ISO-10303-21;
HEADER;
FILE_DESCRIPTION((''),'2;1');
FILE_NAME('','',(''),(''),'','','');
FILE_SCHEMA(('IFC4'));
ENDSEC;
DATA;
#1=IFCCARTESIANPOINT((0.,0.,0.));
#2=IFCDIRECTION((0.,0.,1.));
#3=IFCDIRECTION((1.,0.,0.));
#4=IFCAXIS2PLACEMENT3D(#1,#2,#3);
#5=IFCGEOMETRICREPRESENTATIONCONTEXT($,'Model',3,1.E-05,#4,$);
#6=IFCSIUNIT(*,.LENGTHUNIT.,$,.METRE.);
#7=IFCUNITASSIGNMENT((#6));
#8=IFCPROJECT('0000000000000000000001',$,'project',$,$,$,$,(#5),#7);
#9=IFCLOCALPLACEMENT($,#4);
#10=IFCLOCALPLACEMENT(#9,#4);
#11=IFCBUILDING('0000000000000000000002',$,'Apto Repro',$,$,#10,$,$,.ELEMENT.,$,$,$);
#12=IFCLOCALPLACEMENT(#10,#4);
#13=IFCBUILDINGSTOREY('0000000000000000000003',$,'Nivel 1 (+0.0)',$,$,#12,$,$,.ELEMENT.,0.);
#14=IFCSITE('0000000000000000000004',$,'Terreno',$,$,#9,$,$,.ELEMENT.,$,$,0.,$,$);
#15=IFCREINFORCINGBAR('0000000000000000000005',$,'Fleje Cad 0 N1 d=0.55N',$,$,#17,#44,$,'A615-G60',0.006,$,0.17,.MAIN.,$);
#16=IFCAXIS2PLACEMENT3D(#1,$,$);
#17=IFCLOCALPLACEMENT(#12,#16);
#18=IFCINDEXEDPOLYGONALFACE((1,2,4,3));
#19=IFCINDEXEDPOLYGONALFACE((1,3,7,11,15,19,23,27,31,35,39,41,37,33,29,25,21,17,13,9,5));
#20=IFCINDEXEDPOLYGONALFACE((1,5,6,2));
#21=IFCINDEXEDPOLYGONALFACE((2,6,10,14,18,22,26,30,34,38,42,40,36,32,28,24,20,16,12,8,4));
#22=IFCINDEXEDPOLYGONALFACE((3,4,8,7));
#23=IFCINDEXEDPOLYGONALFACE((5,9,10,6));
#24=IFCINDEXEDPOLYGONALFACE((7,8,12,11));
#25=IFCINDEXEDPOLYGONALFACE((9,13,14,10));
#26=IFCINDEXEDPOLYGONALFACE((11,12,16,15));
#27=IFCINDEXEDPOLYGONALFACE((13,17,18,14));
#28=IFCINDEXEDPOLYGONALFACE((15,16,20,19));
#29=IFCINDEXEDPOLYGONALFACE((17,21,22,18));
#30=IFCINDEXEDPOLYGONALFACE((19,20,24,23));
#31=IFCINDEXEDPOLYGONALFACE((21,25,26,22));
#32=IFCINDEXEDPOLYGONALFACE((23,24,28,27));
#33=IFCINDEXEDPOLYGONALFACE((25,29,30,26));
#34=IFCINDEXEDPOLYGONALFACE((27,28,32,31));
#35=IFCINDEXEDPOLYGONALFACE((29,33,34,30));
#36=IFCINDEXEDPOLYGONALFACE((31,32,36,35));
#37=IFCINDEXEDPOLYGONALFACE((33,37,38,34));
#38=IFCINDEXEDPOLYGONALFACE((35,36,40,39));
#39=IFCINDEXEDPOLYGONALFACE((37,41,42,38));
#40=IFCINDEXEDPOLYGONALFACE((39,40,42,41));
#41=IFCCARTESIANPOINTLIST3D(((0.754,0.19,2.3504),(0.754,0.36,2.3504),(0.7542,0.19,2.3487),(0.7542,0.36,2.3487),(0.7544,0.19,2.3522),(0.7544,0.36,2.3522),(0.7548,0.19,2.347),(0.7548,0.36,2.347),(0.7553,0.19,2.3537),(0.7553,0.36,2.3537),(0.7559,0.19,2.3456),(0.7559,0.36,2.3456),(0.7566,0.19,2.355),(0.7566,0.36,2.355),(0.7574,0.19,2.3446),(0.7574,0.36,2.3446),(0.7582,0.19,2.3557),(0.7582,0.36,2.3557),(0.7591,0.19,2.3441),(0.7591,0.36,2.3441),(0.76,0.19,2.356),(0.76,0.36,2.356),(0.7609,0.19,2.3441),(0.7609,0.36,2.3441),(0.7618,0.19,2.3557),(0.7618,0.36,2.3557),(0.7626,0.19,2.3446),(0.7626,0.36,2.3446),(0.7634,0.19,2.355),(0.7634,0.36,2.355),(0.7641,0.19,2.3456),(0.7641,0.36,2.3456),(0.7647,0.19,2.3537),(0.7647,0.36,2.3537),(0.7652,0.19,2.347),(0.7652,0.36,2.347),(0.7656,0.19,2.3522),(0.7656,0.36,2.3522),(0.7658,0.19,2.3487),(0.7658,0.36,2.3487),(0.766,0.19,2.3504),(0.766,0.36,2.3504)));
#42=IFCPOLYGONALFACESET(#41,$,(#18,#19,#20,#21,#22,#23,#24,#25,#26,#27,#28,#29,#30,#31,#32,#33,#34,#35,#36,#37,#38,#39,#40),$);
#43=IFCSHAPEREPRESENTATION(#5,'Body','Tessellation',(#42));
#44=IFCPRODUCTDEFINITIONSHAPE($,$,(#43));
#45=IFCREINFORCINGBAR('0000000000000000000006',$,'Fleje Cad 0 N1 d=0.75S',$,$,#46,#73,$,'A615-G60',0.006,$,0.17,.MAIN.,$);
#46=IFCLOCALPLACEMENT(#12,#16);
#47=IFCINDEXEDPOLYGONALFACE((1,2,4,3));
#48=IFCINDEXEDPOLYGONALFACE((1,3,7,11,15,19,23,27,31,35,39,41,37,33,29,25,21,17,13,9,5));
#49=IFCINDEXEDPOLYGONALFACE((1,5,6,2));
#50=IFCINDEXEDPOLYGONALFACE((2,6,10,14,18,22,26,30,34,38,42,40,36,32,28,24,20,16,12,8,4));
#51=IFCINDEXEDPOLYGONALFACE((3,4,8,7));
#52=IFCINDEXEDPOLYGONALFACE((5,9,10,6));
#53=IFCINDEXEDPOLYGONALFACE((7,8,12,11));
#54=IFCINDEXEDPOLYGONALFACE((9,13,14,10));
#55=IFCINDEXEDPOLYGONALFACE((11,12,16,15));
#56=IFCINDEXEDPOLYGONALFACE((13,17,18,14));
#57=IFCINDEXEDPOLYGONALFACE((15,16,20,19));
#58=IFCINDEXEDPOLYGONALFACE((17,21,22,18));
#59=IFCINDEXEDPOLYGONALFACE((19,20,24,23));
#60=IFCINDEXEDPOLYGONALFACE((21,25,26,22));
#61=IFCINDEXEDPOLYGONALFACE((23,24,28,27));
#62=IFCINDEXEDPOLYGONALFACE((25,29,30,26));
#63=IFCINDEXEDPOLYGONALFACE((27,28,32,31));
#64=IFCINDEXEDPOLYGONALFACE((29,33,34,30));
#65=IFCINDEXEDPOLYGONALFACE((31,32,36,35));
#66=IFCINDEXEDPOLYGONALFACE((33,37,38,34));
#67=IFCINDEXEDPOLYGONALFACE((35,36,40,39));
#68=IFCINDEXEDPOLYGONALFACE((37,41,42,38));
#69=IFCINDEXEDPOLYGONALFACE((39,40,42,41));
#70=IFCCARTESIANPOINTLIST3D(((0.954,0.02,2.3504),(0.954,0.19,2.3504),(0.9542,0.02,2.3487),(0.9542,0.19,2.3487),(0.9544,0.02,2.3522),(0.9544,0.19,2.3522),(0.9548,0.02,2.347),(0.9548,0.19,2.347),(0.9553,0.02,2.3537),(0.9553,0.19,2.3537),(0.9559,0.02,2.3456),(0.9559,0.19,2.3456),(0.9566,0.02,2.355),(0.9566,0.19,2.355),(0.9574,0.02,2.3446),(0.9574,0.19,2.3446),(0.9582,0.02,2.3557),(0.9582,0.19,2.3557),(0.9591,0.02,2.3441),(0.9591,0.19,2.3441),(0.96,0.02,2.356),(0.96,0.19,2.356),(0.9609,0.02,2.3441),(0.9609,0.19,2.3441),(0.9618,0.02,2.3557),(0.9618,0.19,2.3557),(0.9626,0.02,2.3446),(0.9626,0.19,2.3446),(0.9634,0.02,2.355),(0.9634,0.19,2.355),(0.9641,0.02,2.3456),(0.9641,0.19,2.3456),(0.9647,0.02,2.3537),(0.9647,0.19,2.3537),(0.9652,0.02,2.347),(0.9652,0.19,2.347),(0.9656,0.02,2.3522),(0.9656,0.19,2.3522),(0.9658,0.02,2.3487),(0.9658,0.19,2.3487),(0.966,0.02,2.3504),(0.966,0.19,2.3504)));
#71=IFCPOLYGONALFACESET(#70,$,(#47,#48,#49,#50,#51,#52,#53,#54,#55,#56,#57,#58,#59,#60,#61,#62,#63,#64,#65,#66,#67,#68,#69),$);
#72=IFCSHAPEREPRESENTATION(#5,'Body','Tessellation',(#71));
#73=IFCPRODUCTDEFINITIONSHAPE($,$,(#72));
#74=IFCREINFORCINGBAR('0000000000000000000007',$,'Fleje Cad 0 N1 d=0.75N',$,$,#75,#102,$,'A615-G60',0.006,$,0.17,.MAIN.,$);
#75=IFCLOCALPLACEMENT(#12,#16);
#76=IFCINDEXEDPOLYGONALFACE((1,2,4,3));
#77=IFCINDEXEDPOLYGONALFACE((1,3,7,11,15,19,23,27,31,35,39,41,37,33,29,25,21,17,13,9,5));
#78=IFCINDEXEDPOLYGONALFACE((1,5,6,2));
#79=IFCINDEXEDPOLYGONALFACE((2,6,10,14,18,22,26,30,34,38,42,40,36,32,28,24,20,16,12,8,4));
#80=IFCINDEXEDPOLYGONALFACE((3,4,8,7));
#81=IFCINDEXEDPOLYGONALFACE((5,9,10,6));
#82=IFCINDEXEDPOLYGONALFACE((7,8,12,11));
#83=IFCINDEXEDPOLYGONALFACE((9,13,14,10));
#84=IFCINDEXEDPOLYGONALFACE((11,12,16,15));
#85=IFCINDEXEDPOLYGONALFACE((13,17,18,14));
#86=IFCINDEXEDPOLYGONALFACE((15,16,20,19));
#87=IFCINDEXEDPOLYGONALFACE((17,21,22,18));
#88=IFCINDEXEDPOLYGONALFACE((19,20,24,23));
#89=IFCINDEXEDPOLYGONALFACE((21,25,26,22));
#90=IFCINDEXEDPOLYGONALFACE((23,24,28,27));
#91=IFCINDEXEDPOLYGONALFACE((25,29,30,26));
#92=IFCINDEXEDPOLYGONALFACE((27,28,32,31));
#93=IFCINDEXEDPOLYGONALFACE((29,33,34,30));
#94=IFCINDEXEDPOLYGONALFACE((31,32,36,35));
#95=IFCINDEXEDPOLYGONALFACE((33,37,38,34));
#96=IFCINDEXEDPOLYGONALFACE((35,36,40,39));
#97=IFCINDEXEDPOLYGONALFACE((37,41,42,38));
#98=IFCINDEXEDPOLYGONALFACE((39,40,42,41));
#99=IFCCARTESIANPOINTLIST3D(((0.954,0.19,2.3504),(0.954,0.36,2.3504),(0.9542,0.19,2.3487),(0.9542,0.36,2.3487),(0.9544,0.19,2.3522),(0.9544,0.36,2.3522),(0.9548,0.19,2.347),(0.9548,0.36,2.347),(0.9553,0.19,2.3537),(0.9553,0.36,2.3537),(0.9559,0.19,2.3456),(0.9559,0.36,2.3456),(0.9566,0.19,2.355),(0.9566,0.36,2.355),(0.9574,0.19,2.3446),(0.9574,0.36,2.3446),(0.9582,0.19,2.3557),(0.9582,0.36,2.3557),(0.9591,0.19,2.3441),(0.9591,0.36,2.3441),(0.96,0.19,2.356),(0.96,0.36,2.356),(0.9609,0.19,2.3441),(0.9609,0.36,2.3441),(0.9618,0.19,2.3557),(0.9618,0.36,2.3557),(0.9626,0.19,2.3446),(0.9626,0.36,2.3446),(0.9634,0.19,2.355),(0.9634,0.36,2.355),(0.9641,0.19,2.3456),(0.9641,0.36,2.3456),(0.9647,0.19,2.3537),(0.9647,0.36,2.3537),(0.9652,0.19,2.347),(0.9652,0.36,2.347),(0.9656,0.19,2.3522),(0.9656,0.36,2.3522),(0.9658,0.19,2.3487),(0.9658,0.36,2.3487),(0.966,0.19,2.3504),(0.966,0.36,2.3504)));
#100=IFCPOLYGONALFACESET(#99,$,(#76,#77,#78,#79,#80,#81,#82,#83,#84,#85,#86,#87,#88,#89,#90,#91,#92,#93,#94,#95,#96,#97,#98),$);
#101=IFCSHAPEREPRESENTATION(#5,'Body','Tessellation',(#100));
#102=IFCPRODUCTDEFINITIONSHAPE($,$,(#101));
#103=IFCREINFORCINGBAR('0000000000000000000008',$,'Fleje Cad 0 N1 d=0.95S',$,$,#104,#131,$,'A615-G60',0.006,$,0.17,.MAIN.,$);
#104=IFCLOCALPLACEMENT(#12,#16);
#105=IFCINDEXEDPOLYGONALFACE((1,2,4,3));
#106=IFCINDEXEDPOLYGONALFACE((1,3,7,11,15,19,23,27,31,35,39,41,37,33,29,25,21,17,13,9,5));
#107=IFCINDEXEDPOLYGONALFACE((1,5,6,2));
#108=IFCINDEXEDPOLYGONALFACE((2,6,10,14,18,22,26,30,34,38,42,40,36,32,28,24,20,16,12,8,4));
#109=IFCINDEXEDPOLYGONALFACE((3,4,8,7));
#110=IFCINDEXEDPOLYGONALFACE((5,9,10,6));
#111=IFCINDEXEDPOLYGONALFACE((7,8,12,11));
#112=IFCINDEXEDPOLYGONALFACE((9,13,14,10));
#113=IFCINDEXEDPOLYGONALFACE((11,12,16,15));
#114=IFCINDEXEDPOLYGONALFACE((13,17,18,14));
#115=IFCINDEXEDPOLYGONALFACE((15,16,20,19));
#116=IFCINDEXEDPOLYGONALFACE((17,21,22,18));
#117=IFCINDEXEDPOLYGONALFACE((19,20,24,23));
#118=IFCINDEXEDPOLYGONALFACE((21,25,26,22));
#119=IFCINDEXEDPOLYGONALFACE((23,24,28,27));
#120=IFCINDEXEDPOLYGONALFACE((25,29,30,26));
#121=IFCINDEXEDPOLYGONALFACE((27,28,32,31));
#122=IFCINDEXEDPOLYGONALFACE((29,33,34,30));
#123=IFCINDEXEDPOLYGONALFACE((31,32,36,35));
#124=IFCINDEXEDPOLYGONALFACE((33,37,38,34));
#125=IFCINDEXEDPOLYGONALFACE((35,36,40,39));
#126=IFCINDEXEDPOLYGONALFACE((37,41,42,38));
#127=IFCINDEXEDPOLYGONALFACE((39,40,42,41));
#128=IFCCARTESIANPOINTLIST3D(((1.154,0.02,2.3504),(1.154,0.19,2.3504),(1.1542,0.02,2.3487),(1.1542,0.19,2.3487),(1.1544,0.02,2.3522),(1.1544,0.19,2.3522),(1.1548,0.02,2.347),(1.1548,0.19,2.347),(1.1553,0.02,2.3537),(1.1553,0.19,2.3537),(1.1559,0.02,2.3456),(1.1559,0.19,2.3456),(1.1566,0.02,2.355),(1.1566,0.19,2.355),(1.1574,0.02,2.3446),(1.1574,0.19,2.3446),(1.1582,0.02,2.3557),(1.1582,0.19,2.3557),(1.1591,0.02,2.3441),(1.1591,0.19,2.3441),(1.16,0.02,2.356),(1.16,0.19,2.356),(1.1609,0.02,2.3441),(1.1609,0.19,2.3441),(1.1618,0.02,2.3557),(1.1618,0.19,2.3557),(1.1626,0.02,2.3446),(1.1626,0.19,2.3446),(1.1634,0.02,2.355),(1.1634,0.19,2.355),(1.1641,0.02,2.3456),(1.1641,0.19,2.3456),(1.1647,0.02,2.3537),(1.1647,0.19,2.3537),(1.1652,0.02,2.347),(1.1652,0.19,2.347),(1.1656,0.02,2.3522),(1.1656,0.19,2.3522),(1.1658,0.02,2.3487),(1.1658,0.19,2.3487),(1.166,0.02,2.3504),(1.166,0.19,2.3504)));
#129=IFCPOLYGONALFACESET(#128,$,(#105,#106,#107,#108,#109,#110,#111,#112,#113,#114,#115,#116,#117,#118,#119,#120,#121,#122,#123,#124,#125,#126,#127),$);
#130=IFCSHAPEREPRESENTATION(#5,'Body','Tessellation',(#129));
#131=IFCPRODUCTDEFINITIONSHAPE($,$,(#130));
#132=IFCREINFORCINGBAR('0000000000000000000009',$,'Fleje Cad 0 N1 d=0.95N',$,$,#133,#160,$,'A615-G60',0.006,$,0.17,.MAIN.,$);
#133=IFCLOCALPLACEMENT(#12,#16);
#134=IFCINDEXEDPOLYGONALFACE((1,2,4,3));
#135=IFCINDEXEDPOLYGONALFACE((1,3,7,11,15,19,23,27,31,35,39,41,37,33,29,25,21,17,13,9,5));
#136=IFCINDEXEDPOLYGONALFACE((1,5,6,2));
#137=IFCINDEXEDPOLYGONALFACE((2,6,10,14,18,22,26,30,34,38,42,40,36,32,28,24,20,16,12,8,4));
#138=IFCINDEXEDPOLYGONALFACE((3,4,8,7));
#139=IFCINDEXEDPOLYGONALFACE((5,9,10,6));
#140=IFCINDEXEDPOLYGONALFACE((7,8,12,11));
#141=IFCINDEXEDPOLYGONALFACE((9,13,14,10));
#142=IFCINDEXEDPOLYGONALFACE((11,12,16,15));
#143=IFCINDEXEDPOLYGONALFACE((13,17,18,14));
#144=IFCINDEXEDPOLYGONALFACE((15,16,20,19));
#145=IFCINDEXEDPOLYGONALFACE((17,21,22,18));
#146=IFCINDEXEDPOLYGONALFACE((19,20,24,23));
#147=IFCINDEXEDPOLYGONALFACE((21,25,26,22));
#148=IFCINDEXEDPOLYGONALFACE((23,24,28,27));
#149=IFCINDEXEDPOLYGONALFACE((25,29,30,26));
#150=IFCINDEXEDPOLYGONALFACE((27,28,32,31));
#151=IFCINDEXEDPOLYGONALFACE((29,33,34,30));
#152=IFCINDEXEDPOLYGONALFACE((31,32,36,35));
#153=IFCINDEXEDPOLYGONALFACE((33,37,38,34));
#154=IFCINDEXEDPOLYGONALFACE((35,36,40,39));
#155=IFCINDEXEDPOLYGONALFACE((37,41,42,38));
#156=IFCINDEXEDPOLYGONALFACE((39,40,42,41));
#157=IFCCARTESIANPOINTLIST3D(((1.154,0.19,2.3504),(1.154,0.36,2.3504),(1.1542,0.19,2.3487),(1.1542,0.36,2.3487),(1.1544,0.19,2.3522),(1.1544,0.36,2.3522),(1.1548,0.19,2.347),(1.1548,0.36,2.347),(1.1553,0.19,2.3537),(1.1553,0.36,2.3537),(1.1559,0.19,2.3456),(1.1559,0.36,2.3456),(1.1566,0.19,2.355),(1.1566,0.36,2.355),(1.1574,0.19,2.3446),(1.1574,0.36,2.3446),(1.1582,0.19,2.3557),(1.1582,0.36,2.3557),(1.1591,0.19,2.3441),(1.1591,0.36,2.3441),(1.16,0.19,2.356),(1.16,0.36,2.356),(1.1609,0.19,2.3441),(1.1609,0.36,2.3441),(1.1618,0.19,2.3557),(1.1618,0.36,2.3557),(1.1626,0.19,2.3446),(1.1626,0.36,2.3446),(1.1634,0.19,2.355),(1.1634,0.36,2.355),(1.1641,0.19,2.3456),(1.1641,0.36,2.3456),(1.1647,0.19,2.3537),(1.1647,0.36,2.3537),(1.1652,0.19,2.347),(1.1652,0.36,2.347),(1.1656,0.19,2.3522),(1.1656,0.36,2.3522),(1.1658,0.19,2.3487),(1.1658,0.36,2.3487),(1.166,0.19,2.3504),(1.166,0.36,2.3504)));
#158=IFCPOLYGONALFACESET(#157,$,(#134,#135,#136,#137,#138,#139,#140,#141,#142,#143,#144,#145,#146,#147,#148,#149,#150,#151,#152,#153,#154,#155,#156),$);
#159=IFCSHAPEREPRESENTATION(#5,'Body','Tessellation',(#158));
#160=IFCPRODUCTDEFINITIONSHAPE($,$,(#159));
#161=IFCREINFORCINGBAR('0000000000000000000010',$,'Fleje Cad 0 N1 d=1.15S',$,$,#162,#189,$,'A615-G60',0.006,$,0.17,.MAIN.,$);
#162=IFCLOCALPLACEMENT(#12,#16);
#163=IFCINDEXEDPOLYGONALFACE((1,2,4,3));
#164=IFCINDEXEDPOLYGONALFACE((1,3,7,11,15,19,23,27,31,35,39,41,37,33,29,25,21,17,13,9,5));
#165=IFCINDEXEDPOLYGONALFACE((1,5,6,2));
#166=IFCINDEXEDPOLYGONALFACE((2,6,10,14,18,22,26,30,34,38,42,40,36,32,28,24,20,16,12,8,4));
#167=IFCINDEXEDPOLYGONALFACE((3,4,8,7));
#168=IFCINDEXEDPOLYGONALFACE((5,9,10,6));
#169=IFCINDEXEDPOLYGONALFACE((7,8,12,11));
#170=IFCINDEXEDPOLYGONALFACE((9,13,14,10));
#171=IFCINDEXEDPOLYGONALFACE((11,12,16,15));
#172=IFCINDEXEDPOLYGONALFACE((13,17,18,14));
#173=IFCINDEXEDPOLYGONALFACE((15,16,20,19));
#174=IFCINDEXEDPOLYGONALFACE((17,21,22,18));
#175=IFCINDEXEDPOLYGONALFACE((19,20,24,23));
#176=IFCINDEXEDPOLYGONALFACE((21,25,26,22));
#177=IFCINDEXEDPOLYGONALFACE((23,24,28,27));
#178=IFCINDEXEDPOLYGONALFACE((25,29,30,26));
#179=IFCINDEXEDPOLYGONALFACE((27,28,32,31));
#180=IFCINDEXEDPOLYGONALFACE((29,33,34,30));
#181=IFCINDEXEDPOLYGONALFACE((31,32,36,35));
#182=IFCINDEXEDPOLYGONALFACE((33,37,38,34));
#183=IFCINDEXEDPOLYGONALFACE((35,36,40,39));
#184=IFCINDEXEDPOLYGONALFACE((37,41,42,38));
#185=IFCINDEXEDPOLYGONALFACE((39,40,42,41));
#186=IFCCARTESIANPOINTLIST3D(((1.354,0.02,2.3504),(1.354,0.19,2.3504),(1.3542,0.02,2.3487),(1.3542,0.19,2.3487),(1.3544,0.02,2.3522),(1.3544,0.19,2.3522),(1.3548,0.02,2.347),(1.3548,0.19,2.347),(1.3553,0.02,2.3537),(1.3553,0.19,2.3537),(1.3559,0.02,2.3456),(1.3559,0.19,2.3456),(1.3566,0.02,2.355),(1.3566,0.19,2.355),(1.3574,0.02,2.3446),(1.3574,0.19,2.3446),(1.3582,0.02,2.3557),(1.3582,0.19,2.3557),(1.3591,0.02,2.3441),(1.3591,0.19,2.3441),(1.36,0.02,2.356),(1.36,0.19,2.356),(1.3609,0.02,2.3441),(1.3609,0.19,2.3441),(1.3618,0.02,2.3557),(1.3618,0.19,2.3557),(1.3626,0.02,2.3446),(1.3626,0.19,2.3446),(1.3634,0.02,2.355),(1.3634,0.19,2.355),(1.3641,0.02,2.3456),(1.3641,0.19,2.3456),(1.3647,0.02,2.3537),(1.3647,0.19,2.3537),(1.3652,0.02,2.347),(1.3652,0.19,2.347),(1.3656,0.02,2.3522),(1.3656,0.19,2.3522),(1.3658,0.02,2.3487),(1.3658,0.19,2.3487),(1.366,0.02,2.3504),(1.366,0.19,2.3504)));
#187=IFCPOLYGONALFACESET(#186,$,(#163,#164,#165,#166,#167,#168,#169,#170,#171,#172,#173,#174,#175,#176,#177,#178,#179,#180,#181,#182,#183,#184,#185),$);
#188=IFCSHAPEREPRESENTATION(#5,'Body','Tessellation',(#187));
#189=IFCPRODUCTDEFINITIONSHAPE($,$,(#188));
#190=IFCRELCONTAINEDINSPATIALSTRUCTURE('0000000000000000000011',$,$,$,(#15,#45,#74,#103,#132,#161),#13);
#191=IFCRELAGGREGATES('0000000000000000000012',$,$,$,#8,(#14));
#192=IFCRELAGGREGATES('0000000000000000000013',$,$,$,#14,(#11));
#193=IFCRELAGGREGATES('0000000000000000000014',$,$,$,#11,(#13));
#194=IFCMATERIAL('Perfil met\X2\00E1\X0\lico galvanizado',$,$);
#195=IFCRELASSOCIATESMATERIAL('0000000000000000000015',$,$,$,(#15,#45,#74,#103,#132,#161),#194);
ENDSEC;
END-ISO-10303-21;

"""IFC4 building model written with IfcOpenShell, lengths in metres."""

from ifc_helpers import new_model, si_unit, frame, origin_with_axes, origin_2d_with_axis, place, context, project, spatial, circle, extrude, material, element, save


model = new_model("IFC4")

# Units and contexts
model_context = context("Model", 3, precision=1e-05, world=origin_with_axes())
ifc_project = project(units=[si_unit("LENGTHUNIT", "METRE")], contexts=[model_context])

# Site, building, storey
site_placement = place(None, origin_with_axes())
site = spatial("IfcSite", under=ifc_project, at=site_placement, Name="Terreno", CompositionType="ELEMENT", RefElevation=0.0)
building_placement = place(site_placement, origin_with_axes())
building = spatial("IfcBuilding", under=site, at=building_placement, Name="Apto Repro", CompositionType="ELEMENT")
storey_placement = place(building_placement, origin_with_axes())
storey = spatial("IfcBuildingStorey", under=building, at=storey_placement, Name="Nivel 1 (+0.0)", CompositionType="ELEMENT", Elevation=0.0)

# Reinforcing bars
ifc_material = material(Name="Perfil metálico galvanizado")
reinforcing_bar_1_placement = place(storey_placement, origin_with_axes())
element("IfcReinforcingBar", 1, at=reinforcing_bar_1_placement, inside=storey, material=ifc_material, Name="Fleje Cad 0 N1 d=0.55N", SteelGrade="A615-G60", BarLength=0.17, NominalDiameter=0.006, PredefinedType="MAIN", context=model_context, shape_type="SweptSolid", body=[
    extrude(circle(Radius=0.006, at=origin_2d_with_axis()), frame((0.76, 0.19, 2.35), z_axis=(0.0, 1.0, 0.0), x_axis=(0.0, 0.0, 1.0)), (0.0, 0.0, 1.0), 0.17),
])
reinforcing_bar_2_placement = place(storey_placement, origin_with_axes())
element("IfcReinforcingBar", 2, at=reinforcing_bar_2_placement, inside=storey, material=ifc_material, Name="Fleje Cad 0 N1 d=0.75S", SteelGrade="A615-G60", BarLength=0.17, NominalDiameter=0.006, PredefinedType="MAIN", context=model_context, shape_type="SweptSolid", body=[
    extrude(circle(Radius=0.006, at=origin_2d_with_axis()), frame((0.96, 0.02, 2.35), z_axis=(0.0, 1.0, 0.0), x_axis=(0.0, 0.0, 1.0)), (0.0, 0.0, 1.0), 0.17),
])
reinforcing_bar_3_placement = place(storey_placement, origin_with_axes())
element("IfcReinforcingBar", 3, at=reinforcing_bar_3_placement, inside=storey, material=ifc_material, Name="Fleje Cad 0 N1 d=0.75N", SteelGrade="A615-G60", BarLength=0.17, NominalDiameter=0.006, PredefinedType="MAIN", context=model_context, shape_type="SweptSolid", body=[
    extrude(circle(Radius=0.006, at=origin_2d_with_axis()), frame((0.96, 0.19, 2.35), z_axis=(0.0, 1.0, 0.0), x_axis=(0.0, 0.0, 1.0)), (0.0, 0.0, 1.0), 0.17),
])
reinforcing_bar_4_placement = place(storey_placement, origin_with_axes())
element("IfcReinforcingBar", 4, at=reinforcing_bar_4_placement, inside=storey, material=ifc_material, Name="Fleje Cad 0 N1 d=0.95S", SteelGrade="A615-G60", BarLength=0.17, NominalDiameter=0.006, PredefinedType="MAIN", context=model_context, shape_type="SweptSolid", body=[
    extrude(circle(Radius=0.006, at=origin_2d_with_axis()), frame((1.16, 0.02, 2.35), z_axis=(0.0, 1.0, 0.0), x_axis=(0.0, 0.0, 1.0)), (0.0, 0.0, 1.0), 0.17),
])
reinforcing_bar_5_placement = place(storey_placement, origin_with_axes())
element("IfcReinforcingBar", 5, at=reinforcing_bar_5_placement, inside=storey, material=ifc_material, Name="Fleje Cad 0 N1 d=0.95N", SteelGrade="A615-G60", BarLength=0.17, NominalDiameter=0.006, PredefinedType="MAIN", context=model_context, shape_type="SweptSolid", body=[
    extrude(circle(Radius=0.006, at=origin_2d_with_axis()), frame((1.16, 0.19, 2.35), z_axis=(0.0, 1.0, 0.0), x_axis=(0.0, 0.0, 1.0)), (0.0, 0.0, 1.0), 0.17),
])
reinforcing_bar_6_placement = place(storey_placement, origin_with_axes())
element("IfcReinforcingBar", 6, at=reinforcing_bar_6_placement, inside=storey, material=ifc_material, Name="Fleje Cad 0 N1 d=1.15S", SteelGrade="A615-G60", BarLength=0.17, NominalDiameter=0.006, PredefinedType="MAIN", context=model_context, shape_type="SweptSolid", body=[
    extrude(circle(Radius=0.006, at=origin_2d_with_axis()), frame((1.36, 0.02, 2.35), z_axis=(0.0, 1.0, 0.0), x_axis=(0.0, 0.0, 1.0)), (0.0, 0.0, 1.0), 0.17),
])

save(model, "model.ifc")
